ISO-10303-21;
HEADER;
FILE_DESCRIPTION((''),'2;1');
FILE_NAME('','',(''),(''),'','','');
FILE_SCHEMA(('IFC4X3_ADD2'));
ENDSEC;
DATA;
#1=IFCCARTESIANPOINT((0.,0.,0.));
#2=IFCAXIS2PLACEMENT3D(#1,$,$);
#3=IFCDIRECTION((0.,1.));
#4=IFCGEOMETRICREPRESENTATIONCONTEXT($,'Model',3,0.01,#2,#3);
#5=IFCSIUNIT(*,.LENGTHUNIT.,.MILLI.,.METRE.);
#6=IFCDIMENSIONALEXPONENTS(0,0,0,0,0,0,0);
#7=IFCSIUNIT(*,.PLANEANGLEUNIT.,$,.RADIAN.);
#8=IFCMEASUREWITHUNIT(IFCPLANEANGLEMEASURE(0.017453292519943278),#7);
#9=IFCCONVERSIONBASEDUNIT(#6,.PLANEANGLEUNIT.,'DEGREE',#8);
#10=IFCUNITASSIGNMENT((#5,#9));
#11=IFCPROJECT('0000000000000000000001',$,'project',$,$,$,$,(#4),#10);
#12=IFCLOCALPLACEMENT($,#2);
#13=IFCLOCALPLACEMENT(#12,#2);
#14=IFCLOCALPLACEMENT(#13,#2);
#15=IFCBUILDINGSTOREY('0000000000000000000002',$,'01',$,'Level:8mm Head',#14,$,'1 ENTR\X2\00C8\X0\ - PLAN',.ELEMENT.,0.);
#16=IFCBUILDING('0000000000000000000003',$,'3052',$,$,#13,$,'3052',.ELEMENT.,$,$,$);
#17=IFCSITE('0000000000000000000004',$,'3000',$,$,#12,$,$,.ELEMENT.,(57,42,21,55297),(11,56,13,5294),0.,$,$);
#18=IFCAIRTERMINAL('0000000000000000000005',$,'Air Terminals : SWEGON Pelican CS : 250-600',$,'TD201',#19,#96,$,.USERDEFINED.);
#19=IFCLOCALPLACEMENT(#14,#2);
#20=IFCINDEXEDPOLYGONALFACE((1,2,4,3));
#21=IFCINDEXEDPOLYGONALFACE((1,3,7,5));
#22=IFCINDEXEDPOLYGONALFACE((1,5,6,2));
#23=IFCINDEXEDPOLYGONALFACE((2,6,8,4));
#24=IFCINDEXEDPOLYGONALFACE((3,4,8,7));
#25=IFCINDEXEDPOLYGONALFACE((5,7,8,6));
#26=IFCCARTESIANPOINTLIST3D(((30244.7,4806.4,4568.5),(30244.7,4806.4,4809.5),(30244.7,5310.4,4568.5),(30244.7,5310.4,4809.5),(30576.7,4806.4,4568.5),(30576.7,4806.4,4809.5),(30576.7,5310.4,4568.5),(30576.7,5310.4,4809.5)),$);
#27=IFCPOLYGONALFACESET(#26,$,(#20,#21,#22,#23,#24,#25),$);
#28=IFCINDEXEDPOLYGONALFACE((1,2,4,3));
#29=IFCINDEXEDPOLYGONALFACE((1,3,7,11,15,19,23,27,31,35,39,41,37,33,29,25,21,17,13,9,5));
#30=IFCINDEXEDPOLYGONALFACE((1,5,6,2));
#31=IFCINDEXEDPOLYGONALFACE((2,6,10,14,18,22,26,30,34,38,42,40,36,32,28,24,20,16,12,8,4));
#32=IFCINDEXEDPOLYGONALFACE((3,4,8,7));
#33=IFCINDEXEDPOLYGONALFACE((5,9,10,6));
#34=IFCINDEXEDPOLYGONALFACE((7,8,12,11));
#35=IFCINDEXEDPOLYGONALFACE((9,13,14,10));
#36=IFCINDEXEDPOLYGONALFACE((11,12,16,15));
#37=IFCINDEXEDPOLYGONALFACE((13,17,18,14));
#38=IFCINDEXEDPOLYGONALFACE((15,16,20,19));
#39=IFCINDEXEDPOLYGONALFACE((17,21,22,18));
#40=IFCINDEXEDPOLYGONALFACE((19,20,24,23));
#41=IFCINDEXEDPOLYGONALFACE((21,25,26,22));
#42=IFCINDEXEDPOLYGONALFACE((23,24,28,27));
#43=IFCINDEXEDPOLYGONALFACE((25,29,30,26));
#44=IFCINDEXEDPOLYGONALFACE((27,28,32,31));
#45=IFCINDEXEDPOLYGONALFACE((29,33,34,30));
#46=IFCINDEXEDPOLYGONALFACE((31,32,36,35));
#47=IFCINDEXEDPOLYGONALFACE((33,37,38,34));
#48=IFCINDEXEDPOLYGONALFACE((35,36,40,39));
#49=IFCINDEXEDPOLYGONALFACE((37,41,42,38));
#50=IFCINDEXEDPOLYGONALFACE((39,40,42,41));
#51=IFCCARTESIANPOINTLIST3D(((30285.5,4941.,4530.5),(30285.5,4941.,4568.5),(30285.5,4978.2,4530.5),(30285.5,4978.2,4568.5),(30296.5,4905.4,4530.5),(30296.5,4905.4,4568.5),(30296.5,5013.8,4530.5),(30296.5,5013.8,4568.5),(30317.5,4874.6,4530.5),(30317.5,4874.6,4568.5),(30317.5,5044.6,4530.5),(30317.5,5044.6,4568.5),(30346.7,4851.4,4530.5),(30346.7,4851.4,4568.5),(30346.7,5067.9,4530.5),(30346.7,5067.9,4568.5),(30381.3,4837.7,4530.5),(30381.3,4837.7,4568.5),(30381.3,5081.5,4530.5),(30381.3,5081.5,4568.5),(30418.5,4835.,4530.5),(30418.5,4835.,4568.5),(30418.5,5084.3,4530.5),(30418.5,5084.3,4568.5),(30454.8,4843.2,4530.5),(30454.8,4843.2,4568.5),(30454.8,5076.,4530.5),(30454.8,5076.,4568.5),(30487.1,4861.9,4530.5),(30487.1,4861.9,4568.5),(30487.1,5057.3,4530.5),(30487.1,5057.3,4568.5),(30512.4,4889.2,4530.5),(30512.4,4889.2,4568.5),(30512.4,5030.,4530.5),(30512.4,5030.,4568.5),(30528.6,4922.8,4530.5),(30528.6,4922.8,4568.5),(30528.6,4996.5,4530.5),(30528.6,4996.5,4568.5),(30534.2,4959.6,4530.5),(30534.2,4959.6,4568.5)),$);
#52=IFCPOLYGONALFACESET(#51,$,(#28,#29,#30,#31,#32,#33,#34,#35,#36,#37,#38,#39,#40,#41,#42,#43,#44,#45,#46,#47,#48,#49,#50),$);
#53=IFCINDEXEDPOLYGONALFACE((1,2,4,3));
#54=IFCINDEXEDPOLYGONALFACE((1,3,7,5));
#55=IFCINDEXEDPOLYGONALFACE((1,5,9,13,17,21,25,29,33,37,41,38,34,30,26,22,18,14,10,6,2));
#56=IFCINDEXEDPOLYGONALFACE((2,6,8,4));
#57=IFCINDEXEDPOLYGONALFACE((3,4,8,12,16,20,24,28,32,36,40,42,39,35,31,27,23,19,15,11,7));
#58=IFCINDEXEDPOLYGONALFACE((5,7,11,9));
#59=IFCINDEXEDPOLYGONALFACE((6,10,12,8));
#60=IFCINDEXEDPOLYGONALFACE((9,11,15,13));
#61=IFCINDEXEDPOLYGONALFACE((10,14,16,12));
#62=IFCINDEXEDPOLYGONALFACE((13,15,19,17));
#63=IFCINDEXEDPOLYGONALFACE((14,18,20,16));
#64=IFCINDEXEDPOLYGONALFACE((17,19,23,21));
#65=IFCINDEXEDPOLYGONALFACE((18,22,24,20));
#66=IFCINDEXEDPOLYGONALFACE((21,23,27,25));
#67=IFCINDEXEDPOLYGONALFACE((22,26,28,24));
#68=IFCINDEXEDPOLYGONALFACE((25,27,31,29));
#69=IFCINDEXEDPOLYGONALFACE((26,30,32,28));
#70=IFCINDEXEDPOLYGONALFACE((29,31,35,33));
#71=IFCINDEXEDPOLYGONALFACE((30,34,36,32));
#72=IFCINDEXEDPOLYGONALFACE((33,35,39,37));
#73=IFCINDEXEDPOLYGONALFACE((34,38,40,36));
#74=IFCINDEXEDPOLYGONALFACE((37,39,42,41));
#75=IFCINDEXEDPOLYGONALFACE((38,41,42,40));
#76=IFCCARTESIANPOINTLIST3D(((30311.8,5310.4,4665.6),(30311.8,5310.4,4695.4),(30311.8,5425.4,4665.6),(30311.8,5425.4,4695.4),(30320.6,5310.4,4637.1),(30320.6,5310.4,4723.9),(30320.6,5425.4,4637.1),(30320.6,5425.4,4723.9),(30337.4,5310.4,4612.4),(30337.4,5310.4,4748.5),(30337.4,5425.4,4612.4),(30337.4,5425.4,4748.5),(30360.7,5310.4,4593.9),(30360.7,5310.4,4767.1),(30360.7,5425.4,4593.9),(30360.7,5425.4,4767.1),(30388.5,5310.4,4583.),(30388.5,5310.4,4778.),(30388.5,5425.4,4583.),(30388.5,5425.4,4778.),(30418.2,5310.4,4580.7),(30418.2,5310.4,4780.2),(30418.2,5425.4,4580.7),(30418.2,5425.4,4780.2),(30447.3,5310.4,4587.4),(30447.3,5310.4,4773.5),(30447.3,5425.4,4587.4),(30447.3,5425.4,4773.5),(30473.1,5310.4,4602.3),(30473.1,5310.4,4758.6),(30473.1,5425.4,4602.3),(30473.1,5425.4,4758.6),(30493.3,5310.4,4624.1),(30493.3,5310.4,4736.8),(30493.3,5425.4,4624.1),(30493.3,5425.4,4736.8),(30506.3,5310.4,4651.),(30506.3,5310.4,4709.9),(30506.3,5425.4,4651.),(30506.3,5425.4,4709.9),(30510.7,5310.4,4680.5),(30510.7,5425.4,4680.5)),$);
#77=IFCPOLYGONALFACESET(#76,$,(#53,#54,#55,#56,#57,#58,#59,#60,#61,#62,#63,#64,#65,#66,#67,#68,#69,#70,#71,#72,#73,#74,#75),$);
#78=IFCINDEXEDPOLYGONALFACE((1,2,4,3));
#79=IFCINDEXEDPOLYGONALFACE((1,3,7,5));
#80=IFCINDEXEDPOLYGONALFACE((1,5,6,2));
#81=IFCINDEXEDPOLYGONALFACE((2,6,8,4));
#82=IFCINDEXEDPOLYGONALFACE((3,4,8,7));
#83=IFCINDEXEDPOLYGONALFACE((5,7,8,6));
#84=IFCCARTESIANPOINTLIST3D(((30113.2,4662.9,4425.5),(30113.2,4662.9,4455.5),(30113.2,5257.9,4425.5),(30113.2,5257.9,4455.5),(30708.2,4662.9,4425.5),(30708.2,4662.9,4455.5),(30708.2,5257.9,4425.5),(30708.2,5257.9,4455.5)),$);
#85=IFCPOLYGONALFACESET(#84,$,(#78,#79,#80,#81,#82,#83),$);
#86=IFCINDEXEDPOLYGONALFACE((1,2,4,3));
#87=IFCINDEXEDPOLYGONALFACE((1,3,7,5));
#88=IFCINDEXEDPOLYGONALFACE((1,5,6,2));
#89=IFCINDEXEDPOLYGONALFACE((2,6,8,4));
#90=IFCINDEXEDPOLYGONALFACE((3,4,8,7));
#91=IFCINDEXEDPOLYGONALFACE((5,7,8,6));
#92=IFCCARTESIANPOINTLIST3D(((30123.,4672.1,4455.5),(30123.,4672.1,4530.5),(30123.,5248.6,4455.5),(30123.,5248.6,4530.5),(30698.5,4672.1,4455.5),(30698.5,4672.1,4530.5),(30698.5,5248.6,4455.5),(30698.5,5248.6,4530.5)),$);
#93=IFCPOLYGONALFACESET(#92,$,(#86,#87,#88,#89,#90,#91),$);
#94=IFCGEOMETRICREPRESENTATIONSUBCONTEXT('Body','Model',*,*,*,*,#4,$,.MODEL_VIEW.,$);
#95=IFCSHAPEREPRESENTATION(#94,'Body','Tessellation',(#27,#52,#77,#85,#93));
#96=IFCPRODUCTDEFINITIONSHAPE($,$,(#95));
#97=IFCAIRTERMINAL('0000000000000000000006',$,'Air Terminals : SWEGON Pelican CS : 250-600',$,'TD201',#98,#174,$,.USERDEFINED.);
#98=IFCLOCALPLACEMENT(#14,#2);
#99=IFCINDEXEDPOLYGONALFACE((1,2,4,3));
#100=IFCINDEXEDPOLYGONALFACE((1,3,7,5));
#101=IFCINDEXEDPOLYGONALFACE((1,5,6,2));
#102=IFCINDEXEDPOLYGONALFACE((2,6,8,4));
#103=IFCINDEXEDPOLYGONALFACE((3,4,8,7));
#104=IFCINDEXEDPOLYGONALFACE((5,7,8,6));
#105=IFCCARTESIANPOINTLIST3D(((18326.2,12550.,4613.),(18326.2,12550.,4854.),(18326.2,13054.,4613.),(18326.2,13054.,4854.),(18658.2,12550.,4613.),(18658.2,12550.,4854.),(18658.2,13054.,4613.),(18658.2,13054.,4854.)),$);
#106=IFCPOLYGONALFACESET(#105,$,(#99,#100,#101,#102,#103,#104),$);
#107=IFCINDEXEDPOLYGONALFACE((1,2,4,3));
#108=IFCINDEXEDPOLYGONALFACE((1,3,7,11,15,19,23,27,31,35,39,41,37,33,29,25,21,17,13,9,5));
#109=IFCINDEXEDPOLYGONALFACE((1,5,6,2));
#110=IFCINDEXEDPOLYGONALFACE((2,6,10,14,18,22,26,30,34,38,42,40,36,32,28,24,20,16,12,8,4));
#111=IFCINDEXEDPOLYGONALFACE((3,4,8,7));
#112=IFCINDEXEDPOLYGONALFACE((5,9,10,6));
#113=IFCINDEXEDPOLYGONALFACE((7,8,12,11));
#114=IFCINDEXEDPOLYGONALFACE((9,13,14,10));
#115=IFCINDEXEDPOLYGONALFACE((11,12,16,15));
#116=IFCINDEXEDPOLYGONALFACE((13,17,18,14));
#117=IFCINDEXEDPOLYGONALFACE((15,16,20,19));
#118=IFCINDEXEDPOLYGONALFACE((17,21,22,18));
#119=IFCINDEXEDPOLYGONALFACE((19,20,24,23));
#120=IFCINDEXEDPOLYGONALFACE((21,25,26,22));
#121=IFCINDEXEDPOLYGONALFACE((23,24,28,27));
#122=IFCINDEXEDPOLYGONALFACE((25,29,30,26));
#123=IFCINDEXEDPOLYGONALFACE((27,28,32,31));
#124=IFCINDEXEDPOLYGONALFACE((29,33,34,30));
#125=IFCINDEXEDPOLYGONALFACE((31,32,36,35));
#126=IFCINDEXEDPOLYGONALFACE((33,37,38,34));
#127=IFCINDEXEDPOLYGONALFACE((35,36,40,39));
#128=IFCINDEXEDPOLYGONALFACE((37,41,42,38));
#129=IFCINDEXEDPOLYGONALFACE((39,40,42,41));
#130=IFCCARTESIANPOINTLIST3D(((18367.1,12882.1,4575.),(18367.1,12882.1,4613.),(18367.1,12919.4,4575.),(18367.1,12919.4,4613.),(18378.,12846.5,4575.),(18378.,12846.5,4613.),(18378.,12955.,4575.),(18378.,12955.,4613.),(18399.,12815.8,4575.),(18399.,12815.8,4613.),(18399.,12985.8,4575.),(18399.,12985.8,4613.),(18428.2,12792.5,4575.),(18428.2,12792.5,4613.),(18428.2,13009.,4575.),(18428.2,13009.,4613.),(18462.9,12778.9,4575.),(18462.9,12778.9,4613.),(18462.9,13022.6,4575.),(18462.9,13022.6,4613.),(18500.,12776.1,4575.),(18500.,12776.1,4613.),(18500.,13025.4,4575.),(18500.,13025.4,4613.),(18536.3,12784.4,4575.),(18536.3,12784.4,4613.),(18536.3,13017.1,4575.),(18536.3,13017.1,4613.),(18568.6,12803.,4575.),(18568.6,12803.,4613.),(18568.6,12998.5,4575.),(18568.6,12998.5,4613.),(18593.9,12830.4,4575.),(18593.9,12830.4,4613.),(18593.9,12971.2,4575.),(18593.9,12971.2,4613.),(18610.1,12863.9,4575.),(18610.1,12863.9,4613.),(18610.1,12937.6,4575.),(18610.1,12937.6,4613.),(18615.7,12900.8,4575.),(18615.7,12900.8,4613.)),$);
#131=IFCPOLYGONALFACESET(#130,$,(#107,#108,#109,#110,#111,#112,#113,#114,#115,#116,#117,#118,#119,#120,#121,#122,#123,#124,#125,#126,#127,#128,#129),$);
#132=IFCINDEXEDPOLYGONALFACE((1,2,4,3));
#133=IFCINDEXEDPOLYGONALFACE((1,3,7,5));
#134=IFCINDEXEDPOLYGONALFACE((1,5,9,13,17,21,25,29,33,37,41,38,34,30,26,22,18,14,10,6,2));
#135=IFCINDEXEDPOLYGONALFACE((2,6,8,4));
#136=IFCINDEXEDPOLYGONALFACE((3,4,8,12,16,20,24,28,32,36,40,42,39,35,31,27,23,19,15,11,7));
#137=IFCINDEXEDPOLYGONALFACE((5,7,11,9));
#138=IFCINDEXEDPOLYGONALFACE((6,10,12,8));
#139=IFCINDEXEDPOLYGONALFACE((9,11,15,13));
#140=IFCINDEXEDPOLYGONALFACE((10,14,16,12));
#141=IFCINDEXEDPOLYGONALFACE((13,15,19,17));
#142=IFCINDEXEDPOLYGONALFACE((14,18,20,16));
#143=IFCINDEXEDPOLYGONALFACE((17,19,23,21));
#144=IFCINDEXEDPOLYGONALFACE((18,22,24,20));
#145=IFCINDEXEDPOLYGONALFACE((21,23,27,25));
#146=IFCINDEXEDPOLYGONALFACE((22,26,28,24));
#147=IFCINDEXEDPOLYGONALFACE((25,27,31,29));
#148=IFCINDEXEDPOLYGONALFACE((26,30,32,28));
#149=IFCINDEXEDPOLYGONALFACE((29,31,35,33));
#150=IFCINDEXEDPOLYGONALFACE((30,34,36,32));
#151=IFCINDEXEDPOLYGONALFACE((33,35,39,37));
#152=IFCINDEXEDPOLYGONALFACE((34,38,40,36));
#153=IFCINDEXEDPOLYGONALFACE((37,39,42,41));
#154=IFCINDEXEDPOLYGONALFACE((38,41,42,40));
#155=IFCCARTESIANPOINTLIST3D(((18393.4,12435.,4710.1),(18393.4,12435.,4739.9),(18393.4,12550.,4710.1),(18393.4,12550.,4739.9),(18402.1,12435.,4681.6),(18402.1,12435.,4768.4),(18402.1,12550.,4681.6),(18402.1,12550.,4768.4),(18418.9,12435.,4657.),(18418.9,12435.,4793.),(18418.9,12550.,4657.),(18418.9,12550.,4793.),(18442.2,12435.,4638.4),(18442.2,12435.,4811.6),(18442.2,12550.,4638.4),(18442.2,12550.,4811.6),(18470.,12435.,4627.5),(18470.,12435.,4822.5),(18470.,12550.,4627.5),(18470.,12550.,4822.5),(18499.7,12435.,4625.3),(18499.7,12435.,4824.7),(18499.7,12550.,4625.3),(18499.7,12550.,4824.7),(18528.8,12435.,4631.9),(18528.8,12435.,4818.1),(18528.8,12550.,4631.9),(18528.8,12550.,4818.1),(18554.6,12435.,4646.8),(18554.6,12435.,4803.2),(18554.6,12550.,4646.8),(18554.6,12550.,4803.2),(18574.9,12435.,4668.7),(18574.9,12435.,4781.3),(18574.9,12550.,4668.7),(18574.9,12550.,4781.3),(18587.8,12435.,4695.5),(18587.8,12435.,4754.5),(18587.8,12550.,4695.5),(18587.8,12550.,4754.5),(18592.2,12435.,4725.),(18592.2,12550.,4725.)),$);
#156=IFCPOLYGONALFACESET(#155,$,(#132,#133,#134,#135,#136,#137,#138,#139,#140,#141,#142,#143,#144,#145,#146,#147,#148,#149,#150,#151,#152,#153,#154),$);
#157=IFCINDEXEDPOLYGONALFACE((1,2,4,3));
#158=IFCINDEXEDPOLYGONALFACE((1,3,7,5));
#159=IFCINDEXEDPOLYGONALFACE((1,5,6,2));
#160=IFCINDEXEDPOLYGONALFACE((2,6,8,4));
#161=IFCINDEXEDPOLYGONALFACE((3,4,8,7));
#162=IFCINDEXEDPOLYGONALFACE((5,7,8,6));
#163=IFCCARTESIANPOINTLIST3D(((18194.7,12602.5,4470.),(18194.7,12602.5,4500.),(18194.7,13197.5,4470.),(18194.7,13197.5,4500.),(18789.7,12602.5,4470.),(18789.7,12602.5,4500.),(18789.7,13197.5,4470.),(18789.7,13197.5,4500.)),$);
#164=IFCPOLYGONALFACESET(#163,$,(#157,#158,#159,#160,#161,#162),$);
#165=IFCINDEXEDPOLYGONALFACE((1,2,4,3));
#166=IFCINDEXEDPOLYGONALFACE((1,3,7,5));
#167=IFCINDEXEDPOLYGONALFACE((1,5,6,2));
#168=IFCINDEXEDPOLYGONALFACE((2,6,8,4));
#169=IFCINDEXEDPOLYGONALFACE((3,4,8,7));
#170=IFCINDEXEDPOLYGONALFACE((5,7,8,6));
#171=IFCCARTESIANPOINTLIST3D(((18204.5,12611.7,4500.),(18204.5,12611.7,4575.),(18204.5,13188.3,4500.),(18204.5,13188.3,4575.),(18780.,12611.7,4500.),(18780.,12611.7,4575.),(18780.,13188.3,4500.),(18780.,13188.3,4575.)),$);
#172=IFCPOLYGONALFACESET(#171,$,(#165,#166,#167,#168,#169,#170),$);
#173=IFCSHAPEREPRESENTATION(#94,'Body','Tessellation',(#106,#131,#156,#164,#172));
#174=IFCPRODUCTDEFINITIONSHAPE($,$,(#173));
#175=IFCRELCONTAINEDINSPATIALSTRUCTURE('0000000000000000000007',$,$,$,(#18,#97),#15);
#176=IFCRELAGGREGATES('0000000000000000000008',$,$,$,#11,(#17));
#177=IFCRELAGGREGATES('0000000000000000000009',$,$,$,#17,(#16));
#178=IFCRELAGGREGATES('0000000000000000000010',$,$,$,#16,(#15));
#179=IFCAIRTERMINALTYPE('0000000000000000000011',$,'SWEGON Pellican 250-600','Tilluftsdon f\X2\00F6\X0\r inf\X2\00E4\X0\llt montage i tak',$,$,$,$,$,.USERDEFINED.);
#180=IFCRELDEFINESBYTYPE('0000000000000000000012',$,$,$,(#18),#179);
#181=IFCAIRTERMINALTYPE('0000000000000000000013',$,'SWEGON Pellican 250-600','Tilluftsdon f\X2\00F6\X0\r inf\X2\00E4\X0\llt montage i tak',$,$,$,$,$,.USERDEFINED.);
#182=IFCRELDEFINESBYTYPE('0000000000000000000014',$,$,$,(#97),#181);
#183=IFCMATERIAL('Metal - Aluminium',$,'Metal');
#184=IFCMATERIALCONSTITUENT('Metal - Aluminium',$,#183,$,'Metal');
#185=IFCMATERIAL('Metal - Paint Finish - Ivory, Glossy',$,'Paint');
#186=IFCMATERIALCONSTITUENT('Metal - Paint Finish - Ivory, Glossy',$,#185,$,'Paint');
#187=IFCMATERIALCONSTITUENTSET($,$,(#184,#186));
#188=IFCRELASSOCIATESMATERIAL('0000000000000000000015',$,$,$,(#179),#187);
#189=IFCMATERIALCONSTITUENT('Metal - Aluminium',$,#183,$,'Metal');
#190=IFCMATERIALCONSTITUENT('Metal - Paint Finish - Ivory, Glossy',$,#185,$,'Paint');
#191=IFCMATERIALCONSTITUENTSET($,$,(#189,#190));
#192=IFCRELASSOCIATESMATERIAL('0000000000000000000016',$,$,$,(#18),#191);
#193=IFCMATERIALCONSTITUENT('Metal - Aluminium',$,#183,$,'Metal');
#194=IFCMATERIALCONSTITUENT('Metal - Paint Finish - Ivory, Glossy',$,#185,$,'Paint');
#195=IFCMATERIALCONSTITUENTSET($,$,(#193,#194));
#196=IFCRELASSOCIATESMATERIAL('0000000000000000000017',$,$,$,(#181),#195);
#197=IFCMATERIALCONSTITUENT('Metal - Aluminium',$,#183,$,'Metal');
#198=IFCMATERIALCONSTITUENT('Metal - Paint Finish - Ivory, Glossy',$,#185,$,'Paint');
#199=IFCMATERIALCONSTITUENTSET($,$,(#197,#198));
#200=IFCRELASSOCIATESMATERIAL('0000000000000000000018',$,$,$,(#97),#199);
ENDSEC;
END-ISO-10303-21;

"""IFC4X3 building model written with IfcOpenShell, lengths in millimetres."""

from ifc_helpers import new_model, entity, si_unit, converted_unit, direction, frame, frame_2d, origin, origin_2d_with_axis, place, context, subcontext, project, spatial, rectangle, circle, extrude, source, transform, mapped, material, constituent, constituent_set, type_object, type_shapes, element, save


model = new_model("IFC4X3")

# Units and contexts
model_context = context("Model", 3, precision=0.01, world=origin(), true_north=direction((0.0, 1.0)))
body_context = subcontext(model_context, "Body", "Model", "MODEL_VIEW")
ifc_project = project(units=[si_unit("LENGTHUNIT", "METRE", prefix="MILLI"), converted_unit("PLANEANGLEUNIT", "DEGREE", entity("IfcPlaneAngleMeasure", 0.017453292519943278), si_unit("PLANEANGLEUNIT", "RADIAN"), dimensions=[0, 0, 0, 0, 0, 0, 0])], contexts=[model_context])

# Site, building, storey
site_placement = place(None, origin())
site = spatial("IfcSite", under=ifc_project, at=site_placement, Name="3000", CompositionType="ELEMENT", RefLatitude=(57, 42, 21, 55297), RefLongitude=(11, 56, 13, 5294), RefElevation=0.0)
building_placement = place(site_placement, origin())
building = spatial("IfcBuilding", under=site, at=building_placement, Name="3052", LongName="3052", CompositionType="ELEMENT")
storey_placement = place(building_placement, origin())
storey = spatial("IfcBuildingStorey", under=building, at=storey_placement, Name="01", ObjectType="Level:8mm Head", LongName="1 ENTRÈ - PLAN", CompositionType="ELEMENT", Elevation=0.0)

# Shared definitions
ifc_material_1 = material(Name="Metal - Aluminium", Category="Metal")
ifc_material_2 = material(Name="Metal - Paint Finish - Ivory, Glossy", Category="Paint")

# Air terminal
ifc_constituent_1 = constituent(ifc_material_1, Name="Metal - Aluminium", Category="Metal")
ifc_constituent_2 = constituent(ifc_material_2, Name="Metal - Paint Finish - Ivory, Glossy", Category="Paint")
ifc_constituent_set_1 = constituent_set(constituents=[ifc_constituent_1, ifc_constituent_2])
ifc_constituent_3 = constituent(ifc_material_1, Name="Metal - Aluminium", Category="Metal")
ifc_constituent_4 = constituent(ifc_material_2, Name="Metal - Paint Finish - Ivory, Glossy", Category="Paint")
ifc_constituent_set_2 = constituent_set(constituents=[ifc_constituent_3, ifc_constituent_4])
air_terminal_type_1 = type_object("IfcAirTerminalType", Name="SWEGON Pellican 250-600", Description="Tilluftsdon för infällt montage i tak", PredefinedType="USERDEFINED", material=ifc_constituent_set_2)
shared_shape_1 = source(origin(), body_context, "Body", "SweptSolid", [
    extrude(rectangle(XDim=504.0, YDim=332.0, at=origin_2d_with_axis()), frame((0.0, -98.0, -354.0), z_axis=(0.0, 0.0, 1.0), x_axis=(0.0, 1.0, 0.0)), (0.0, 0.0, 1.0), 241.0),
    extrude(circle(Radius=125.0, at=frame_2d((0.0, 0.0), x_axis=(1.0, 0.0))), frame((-1.6, 0.8, -113.0)), (0.0, 0.0, 1.0), 38.0),
    extrude(circle(Radius=100.0, at=frame_2d((0.0, 0.0), x_axis=(1.0, 0.0))), frame((0.0, -465.0, -225.0), z_axis=(0.0, 1.0, 0.0), x_axis=(1.0, 0.0, 0.0)), (0.0, 0.0, 1.0), 115.0),
    extrude(rectangle(XDim=595.0, YDim=595.0, at=frame_2d((0.0, 0.0), x_axis=(1.0, 0.0))), frame((0.0, 0.0, 0.0), z_axis=(0.0, 0.0, 1.0), x_axis=(0.0, 1.0, 0.0)), (0.0, 0.0, 1.0), 30.0),
    extrude(rectangle(XDim=576.5, YDim=575.5, at=origin_2d_with_axis()), frame((0.0, 0.0, -75.0), z_axis=(0.0, 0.0, 1.0), x_axis=(0.0, 1.0, 0.0)), (0.0, 0.0, 1.0), 75.0),
])
type_shapes(air_terminal_type_1, [shared_shape_1])
air_terminal_1_placement = place(storey_placement, frame((30410.7, 4960.4, 4455.5), z_axis=(0.0, 0.0, -1.0), x_axis=(1.0, 0.0, 0.0)))
element("IfcAirTerminal", 1, at=air_terminal_1_placement, inside=storey, type_object=air_terminal_type_1, material=ifc_constituent_set_1, Name="Air Terminals : SWEGON Pelican CS : 250-600", ObjectType="TD201", PredefinedType="USERDEFINED", context=body_context, shape_type="MappedRepresentation", body=[
    mapped(shared_shape_1, transform((0.0, 0.0, 0.0), scale=1.0)),
])

# Air terminal
ifc_constituent_5 = constituent(ifc_material_1, Name="Metal - Aluminium", Category="Metal")
ifc_constituent_6 = constituent(ifc_material_2, Name="Metal - Paint Finish - Ivory, Glossy", Category="Paint")
ifc_constituent_set_3 = constituent_set(constituents=[ifc_constituent_5, ifc_constituent_6])
ifc_constituent_7 = constituent(ifc_material_1, Name="Metal - Aluminium", Category="Metal")
ifc_constituent_8 = constituent(ifc_material_2, Name="Metal - Paint Finish - Ivory, Glossy", Category="Paint")
ifc_constituent_set_4 = constituent_set(constituents=[ifc_constituent_7, ifc_constituent_8])
air_terminal_type_2 = type_object("IfcAirTerminalType", Name="SWEGON Pellican 250-600", Description="Tilluftsdon för infällt montage i tak", PredefinedType="USERDEFINED", material=ifc_constituent_set_4)
shared_shape_2 = source(origin(), body_context, "Body", "SweptSolid", [
    extrude(rectangle(XDim=332.0, YDim=504.0, at=origin_2d_with_axis()), frame((0.0, 98.0, -354.0), z_axis=(0.0, 0.0, 1.0), x_axis=(-1.0, 0.0, 0.0)), (0.0, 0.0, 1.0), 241.0),
    extrude(circle(Radius=125.0, at=frame_2d((0.0, 0.0), x_axis=(1.0, 0.0))), frame((-1.6, -0.8, -113.0)), (0.0, 0.0, 1.0), 38.0),
    extrude(circle(Radius=100.0, at=frame_2d((0.0, 0.0), x_axis=(1.0, 0.0))), frame((0.0, 350.0, -225.0), z_axis=(0.0, 1.0, 0.0), x_axis=(1.0, 0.0, 0.0)), (0.0, 0.0, 1.0), 115.0),
    extrude(rectangle(XDim=595.0, YDim=595.0, at=frame_2d((0.0, 0.0), x_axis=(1.0, 0.0))), frame((0.0, 0.0, 0.0), z_axis=(0.0, 0.0, 1.0), x_axis=(-1.0, 0.0, 0.0)), (0.0, 0.0, 1.0), 30.0),
    extrude(rectangle(XDim=575.5, YDim=576.5, at=origin_2d_with_axis()), frame((0.0, 0.0, -75.0), z_axis=(0.0, 0.0, 1.0), x_axis=(-1.0, 0.0, 0.0)), (0.0, 0.0, 1.0), 75.0),
])
type_shapes(air_terminal_type_2, [shared_shape_2])
air_terminal_2_placement = place(storey_placement, frame((18492.2, 12900.0, 4500.0), z_axis=(0.0, 0.0, -1.0), x_axis=(1.0, 0.0, 0.0)))
element("IfcAirTerminal", 2, at=air_terminal_2_placement, inside=storey, type_object=air_terminal_type_2, material=ifc_constituent_set_3, Name="Air Terminals : SWEGON Pelican CS : 250-600", ObjectType="TD201", PredefinedType="USERDEFINED", context=body_context, shape_type="MappedRepresentation", body=[
    mapped(shared_shape_2, transform((0.0, 0.0, 0.0), scale=1.0)),
])

save(model, "model.ifc")
